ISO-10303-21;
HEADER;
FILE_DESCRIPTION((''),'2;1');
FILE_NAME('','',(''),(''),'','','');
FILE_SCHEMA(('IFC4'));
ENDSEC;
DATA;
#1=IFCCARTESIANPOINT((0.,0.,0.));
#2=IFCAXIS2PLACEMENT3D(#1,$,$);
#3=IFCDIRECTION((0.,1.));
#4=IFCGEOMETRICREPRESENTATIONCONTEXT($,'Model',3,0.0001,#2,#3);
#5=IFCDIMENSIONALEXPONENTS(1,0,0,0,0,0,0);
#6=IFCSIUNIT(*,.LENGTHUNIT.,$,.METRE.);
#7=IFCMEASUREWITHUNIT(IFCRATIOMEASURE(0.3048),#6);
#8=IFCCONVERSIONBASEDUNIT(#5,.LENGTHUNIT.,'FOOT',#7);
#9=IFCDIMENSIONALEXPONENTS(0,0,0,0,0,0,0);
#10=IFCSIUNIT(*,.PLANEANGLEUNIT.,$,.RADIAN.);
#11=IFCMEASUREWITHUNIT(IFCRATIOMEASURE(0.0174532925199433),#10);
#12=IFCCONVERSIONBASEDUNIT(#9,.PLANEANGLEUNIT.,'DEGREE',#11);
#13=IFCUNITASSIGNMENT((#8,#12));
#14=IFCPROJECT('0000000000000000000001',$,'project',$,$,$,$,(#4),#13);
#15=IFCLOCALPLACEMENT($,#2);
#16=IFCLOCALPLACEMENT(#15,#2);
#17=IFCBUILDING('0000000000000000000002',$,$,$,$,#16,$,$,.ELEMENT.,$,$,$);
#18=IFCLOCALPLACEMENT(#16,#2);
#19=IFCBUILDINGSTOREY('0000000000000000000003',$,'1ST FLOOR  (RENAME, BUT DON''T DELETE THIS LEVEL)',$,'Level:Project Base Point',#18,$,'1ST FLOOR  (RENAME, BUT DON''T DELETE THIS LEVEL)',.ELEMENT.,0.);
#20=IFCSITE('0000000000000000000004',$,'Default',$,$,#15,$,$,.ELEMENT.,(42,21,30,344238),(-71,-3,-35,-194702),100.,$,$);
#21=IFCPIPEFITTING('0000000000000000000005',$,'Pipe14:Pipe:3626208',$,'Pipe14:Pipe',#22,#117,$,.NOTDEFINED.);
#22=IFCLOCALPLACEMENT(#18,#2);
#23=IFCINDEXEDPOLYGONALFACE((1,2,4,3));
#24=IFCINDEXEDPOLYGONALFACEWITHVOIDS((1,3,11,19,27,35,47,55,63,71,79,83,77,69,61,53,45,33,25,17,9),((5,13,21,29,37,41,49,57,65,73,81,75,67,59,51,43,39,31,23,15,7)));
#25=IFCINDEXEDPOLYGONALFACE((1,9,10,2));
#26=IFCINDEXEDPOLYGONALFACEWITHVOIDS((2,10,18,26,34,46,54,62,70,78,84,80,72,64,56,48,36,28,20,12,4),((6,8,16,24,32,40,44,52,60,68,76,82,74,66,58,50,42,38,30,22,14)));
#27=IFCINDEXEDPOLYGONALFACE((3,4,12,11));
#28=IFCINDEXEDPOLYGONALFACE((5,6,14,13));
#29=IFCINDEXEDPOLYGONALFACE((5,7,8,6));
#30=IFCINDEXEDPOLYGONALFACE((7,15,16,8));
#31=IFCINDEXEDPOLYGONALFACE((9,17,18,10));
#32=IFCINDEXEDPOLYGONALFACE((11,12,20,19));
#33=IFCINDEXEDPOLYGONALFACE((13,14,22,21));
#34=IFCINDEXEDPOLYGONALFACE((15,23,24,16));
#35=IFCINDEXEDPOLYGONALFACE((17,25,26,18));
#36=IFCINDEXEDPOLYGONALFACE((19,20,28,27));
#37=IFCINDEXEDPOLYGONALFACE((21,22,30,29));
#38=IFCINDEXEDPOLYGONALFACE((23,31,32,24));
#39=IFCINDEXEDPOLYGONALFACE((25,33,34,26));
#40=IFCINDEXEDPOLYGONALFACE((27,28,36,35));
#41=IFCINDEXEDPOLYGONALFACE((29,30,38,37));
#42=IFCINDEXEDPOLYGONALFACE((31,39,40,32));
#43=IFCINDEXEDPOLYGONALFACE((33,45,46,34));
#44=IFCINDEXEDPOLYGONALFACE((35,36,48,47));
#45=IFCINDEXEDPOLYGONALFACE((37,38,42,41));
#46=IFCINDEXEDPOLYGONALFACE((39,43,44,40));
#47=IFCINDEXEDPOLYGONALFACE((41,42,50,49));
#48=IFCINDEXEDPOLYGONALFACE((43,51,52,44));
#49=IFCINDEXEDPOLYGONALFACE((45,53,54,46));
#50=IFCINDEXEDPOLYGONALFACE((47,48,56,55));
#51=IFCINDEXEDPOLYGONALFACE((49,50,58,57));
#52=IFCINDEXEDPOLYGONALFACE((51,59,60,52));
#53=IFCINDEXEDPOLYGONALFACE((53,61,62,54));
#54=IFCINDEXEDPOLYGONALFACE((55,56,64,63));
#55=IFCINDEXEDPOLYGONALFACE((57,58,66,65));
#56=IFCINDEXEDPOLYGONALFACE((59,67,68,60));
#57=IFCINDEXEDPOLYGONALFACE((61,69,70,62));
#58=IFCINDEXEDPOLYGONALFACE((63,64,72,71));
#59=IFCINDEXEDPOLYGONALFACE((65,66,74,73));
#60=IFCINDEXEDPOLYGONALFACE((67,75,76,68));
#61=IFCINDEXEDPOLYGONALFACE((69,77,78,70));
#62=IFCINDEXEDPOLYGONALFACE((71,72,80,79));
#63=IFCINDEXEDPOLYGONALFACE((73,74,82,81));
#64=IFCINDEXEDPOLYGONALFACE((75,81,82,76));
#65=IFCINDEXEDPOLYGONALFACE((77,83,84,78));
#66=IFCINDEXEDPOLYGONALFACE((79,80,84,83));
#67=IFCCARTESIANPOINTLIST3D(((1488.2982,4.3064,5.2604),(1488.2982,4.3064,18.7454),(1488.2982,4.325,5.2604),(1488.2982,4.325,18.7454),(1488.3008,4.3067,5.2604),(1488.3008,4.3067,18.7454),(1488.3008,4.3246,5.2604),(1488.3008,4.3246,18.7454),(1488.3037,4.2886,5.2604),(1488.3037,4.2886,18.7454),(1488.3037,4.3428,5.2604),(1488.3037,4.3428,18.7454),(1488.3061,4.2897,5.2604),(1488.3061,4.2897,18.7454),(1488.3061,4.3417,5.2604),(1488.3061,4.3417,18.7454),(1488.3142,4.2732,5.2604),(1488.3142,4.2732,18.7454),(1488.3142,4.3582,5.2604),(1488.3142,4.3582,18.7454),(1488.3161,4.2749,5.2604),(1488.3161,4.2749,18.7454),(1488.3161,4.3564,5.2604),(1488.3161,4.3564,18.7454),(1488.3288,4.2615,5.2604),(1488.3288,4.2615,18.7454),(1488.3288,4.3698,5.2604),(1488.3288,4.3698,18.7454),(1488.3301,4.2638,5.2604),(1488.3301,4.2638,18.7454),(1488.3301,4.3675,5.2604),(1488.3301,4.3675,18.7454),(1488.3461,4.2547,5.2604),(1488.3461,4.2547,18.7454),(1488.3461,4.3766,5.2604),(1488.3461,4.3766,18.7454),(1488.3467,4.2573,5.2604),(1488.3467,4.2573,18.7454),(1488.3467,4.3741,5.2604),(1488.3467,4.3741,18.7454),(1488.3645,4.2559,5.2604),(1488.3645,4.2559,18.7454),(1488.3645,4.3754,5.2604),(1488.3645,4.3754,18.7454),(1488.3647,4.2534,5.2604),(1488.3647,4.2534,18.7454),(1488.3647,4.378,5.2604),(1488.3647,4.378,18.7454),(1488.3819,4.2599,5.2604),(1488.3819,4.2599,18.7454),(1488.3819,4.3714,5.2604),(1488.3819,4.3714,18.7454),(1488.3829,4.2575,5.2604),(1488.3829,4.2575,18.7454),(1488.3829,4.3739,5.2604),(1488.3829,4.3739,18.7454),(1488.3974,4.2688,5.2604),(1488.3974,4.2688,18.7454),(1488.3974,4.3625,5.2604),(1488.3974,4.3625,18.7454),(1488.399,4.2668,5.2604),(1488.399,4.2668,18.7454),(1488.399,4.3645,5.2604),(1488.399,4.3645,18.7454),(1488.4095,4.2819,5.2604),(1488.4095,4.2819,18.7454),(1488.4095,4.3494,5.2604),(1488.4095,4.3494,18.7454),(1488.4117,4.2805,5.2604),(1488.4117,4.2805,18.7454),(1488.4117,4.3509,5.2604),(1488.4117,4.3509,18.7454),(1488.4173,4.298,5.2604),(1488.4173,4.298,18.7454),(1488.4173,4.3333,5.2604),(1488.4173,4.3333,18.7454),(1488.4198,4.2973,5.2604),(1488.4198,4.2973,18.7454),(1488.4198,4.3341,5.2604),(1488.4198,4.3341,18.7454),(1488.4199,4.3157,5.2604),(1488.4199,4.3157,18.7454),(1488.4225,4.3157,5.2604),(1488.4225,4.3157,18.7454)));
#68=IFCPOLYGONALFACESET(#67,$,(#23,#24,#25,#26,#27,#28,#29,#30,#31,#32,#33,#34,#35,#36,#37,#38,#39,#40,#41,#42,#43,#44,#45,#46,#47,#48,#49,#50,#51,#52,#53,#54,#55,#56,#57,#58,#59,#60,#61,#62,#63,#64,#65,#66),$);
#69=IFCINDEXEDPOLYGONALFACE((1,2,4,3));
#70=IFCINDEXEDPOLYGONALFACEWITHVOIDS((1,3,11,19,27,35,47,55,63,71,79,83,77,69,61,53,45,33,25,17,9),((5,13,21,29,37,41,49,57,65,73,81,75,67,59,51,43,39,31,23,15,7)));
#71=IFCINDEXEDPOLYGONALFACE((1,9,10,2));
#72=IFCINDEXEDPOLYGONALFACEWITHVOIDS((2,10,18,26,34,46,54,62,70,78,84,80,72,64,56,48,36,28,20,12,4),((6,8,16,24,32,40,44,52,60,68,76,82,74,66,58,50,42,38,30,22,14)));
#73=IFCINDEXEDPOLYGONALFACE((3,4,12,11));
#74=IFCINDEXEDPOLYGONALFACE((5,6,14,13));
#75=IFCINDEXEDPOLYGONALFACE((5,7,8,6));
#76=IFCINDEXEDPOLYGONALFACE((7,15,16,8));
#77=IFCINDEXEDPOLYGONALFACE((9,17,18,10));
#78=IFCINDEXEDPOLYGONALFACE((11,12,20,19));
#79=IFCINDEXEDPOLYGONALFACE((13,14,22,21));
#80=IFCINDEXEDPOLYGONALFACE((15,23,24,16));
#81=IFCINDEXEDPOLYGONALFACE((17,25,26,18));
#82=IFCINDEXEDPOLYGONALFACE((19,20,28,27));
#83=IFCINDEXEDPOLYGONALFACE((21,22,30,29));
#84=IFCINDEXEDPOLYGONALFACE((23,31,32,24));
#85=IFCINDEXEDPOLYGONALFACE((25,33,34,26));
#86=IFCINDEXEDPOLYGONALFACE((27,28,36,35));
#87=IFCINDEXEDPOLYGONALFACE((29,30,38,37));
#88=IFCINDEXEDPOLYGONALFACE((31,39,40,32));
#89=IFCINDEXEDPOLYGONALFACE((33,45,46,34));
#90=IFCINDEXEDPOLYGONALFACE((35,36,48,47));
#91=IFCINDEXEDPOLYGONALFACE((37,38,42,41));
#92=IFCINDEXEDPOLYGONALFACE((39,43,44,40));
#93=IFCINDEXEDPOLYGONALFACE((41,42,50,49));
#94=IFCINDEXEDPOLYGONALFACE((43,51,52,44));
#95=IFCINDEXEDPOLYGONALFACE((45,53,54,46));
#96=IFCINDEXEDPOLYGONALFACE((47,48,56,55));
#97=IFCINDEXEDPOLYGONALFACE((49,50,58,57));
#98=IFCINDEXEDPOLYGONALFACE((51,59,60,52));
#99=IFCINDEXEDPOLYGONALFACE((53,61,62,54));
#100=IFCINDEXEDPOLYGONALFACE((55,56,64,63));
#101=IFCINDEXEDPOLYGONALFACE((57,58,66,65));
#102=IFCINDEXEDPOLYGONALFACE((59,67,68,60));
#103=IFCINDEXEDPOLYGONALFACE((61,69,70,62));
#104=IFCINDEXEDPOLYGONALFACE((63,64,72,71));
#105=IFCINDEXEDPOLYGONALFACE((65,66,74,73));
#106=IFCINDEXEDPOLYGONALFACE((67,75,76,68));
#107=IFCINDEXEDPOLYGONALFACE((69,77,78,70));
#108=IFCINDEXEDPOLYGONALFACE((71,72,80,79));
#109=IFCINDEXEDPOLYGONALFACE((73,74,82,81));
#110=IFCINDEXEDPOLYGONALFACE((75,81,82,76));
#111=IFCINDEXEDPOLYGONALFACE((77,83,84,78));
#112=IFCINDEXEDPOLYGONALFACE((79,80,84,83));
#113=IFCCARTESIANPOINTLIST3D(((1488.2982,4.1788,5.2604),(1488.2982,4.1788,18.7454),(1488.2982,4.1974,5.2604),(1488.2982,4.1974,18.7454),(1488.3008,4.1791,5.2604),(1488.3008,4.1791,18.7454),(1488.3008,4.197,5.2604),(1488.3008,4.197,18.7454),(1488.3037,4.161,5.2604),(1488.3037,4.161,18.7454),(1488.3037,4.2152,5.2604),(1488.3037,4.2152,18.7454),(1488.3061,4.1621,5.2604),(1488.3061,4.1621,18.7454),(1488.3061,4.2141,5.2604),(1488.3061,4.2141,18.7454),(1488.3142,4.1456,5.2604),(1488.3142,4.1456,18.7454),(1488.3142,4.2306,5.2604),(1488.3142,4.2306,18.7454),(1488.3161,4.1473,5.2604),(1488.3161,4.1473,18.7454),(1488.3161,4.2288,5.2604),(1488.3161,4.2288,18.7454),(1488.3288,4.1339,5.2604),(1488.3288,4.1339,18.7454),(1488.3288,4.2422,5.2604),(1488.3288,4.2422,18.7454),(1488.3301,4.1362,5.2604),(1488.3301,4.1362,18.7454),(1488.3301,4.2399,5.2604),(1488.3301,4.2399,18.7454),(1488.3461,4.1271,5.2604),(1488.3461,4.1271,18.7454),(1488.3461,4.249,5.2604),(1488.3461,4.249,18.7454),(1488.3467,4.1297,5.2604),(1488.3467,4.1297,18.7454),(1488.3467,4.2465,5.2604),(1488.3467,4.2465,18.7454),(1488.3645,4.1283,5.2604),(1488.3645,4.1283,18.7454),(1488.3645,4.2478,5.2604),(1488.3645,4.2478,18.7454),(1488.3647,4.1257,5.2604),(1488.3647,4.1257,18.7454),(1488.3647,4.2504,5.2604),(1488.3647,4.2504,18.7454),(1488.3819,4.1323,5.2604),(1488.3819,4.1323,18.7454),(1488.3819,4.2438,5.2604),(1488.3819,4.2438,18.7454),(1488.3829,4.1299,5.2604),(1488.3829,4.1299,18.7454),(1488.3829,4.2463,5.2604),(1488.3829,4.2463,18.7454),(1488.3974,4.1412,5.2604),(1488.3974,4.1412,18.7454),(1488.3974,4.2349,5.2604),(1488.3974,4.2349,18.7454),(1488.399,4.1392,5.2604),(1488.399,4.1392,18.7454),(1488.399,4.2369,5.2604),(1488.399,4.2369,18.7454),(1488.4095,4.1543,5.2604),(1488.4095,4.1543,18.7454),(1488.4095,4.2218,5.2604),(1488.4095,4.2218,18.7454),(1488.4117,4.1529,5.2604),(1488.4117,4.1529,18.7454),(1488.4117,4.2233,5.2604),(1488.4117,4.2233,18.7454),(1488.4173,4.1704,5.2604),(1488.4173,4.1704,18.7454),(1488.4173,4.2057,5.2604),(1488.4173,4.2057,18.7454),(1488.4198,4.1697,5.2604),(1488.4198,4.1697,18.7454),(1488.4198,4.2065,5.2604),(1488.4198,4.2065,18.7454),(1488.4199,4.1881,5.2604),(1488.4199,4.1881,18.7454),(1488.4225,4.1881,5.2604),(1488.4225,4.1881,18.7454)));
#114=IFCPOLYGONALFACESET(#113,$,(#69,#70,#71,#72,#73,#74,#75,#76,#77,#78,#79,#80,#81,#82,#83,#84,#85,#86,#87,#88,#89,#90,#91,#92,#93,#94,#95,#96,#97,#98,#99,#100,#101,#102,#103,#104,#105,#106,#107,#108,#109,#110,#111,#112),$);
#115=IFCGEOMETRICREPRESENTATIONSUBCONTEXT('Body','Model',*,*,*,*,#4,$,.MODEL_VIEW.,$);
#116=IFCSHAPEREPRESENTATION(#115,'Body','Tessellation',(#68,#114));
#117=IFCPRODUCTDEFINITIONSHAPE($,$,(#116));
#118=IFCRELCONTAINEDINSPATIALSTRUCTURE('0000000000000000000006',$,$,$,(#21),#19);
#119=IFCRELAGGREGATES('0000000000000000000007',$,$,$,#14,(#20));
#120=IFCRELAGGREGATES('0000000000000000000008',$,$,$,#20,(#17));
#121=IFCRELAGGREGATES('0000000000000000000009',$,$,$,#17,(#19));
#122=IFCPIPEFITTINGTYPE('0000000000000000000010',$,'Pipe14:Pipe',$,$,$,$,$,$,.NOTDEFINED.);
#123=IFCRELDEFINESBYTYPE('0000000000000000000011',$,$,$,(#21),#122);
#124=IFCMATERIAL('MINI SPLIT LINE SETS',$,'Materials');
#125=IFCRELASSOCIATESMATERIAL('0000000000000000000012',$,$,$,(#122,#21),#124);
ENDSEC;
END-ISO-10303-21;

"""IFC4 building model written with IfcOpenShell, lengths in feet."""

from ifc_helpers import new_model, entity, si_unit, converted_unit, direction, frame, origin, origin_2d_with_axis, place, context, subcontext, project, spatial, hollow_circle, extrude, source, transform, mapped, material, type_object, type_shapes, element, save


model = new_model("IFC4")

# Units and contexts
model_context = context("Model", 3, precision=0.0001, world=origin(), true_north=direction((0.0, 1.0)))
body_context = subcontext(model_context, "Body", "Model", "MODEL_VIEW")
ifc_project = project(units=[converted_unit("LENGTHUNIT", "FOOT", entity("IfcRatioMeasure", 0.3048), si_unit("LENGTHUNIT", "METRE"), dimensions=[1, 0, 0, 0, 0, 0, 0]), converted_unit("PLANEANGLEUNIT", "DEGREE", entity("IfcRatioMeasure", 0.0174532925199433), si_unit("PLANEANGLEUNIT", "RADIAN"), dimensions=[0, 0, 0, 0, 0, 0, 0])], contexts=[model_context])

# Site, building, storey
site_placement = place(None, origin())
site = spatial("IfcSite", under=ifc_project, at=site_placement, Name="Default", CompositionType="ELEMENT", RefLatitude=(42, 21, 30, 344238), RefLongitude=(-71, -3, -35, -194702), RefElevation=100.0)
building_placement = place(site_placement, origin())
building = spatial("IfcBuilding", under=site, at=building_placement, CompositionType="ELEMENT")
storey_placement = place(building_placement, origin())
storey = spatial("IfcBuildingStorey", under=building, at=storey_placement, Name="1ST FLOOR  (RENAME, BUT DON'T DELETE THIS LEVEL)", ObjectType="Level:Project Base Point", LongName="1ST FLOOR  (RENAME, BUT DON'T DELETE THIS LEVEL)", CompositionType="ELEMENT", Elevation=0.0)

# Shared definitions
ifc_material_1 = material(Name="MINI SPLIT LINE SETS", Category="Materials")

# Pipe fitting
pipe_fitting_type_1 = type_object("IfcPipeFittingType", Name="Pipe14:Pipe", PredefinedType="NOTDEFINED", material=ifc_material_1)
shared_shape_1 = source(origin(), body_context, "Body", "SweptSolid", [
    extrude(hollow_circle(Radius=0.0625, WallThickness=0.0026, at=origin_2d_with_axis()), frame((0.0677, 0.1953, 0.0)), (0.0, 0.0, 1.0), 13.485),
    extrude(hollow_circle(Radius=0.0625, WallThickness=0.0026, at=origin_2d_with_axis()), frame((0.0677, 0.0677, 0.0)), (0.0, 0.0, 1.0), 13.485),
])
type_shapes(pipe_fitting_type_1, [shared_shape_1])
pipe_fitting_1_placement = place(storey_placement, frame((1488.2923, 4.1203, 5.2604)))
element("IfcPipeFitting", 1, at=pipe_fitting_1_placement, inside=storey, type_object=pipe_fitting_type_1, material=ifc_material_1, Name="Pipe14:Pipe:3626208", ObjectType="Pipe14:Pipe", PredefinedType="NOTDEFINED", context=body_context, shape_type="MappedRepresentation", body=[
    mapped(shared_shape_1, transform((0.0, 0.0, 0.0), scale=1.0)),
])

save(model, "model.ifc")
